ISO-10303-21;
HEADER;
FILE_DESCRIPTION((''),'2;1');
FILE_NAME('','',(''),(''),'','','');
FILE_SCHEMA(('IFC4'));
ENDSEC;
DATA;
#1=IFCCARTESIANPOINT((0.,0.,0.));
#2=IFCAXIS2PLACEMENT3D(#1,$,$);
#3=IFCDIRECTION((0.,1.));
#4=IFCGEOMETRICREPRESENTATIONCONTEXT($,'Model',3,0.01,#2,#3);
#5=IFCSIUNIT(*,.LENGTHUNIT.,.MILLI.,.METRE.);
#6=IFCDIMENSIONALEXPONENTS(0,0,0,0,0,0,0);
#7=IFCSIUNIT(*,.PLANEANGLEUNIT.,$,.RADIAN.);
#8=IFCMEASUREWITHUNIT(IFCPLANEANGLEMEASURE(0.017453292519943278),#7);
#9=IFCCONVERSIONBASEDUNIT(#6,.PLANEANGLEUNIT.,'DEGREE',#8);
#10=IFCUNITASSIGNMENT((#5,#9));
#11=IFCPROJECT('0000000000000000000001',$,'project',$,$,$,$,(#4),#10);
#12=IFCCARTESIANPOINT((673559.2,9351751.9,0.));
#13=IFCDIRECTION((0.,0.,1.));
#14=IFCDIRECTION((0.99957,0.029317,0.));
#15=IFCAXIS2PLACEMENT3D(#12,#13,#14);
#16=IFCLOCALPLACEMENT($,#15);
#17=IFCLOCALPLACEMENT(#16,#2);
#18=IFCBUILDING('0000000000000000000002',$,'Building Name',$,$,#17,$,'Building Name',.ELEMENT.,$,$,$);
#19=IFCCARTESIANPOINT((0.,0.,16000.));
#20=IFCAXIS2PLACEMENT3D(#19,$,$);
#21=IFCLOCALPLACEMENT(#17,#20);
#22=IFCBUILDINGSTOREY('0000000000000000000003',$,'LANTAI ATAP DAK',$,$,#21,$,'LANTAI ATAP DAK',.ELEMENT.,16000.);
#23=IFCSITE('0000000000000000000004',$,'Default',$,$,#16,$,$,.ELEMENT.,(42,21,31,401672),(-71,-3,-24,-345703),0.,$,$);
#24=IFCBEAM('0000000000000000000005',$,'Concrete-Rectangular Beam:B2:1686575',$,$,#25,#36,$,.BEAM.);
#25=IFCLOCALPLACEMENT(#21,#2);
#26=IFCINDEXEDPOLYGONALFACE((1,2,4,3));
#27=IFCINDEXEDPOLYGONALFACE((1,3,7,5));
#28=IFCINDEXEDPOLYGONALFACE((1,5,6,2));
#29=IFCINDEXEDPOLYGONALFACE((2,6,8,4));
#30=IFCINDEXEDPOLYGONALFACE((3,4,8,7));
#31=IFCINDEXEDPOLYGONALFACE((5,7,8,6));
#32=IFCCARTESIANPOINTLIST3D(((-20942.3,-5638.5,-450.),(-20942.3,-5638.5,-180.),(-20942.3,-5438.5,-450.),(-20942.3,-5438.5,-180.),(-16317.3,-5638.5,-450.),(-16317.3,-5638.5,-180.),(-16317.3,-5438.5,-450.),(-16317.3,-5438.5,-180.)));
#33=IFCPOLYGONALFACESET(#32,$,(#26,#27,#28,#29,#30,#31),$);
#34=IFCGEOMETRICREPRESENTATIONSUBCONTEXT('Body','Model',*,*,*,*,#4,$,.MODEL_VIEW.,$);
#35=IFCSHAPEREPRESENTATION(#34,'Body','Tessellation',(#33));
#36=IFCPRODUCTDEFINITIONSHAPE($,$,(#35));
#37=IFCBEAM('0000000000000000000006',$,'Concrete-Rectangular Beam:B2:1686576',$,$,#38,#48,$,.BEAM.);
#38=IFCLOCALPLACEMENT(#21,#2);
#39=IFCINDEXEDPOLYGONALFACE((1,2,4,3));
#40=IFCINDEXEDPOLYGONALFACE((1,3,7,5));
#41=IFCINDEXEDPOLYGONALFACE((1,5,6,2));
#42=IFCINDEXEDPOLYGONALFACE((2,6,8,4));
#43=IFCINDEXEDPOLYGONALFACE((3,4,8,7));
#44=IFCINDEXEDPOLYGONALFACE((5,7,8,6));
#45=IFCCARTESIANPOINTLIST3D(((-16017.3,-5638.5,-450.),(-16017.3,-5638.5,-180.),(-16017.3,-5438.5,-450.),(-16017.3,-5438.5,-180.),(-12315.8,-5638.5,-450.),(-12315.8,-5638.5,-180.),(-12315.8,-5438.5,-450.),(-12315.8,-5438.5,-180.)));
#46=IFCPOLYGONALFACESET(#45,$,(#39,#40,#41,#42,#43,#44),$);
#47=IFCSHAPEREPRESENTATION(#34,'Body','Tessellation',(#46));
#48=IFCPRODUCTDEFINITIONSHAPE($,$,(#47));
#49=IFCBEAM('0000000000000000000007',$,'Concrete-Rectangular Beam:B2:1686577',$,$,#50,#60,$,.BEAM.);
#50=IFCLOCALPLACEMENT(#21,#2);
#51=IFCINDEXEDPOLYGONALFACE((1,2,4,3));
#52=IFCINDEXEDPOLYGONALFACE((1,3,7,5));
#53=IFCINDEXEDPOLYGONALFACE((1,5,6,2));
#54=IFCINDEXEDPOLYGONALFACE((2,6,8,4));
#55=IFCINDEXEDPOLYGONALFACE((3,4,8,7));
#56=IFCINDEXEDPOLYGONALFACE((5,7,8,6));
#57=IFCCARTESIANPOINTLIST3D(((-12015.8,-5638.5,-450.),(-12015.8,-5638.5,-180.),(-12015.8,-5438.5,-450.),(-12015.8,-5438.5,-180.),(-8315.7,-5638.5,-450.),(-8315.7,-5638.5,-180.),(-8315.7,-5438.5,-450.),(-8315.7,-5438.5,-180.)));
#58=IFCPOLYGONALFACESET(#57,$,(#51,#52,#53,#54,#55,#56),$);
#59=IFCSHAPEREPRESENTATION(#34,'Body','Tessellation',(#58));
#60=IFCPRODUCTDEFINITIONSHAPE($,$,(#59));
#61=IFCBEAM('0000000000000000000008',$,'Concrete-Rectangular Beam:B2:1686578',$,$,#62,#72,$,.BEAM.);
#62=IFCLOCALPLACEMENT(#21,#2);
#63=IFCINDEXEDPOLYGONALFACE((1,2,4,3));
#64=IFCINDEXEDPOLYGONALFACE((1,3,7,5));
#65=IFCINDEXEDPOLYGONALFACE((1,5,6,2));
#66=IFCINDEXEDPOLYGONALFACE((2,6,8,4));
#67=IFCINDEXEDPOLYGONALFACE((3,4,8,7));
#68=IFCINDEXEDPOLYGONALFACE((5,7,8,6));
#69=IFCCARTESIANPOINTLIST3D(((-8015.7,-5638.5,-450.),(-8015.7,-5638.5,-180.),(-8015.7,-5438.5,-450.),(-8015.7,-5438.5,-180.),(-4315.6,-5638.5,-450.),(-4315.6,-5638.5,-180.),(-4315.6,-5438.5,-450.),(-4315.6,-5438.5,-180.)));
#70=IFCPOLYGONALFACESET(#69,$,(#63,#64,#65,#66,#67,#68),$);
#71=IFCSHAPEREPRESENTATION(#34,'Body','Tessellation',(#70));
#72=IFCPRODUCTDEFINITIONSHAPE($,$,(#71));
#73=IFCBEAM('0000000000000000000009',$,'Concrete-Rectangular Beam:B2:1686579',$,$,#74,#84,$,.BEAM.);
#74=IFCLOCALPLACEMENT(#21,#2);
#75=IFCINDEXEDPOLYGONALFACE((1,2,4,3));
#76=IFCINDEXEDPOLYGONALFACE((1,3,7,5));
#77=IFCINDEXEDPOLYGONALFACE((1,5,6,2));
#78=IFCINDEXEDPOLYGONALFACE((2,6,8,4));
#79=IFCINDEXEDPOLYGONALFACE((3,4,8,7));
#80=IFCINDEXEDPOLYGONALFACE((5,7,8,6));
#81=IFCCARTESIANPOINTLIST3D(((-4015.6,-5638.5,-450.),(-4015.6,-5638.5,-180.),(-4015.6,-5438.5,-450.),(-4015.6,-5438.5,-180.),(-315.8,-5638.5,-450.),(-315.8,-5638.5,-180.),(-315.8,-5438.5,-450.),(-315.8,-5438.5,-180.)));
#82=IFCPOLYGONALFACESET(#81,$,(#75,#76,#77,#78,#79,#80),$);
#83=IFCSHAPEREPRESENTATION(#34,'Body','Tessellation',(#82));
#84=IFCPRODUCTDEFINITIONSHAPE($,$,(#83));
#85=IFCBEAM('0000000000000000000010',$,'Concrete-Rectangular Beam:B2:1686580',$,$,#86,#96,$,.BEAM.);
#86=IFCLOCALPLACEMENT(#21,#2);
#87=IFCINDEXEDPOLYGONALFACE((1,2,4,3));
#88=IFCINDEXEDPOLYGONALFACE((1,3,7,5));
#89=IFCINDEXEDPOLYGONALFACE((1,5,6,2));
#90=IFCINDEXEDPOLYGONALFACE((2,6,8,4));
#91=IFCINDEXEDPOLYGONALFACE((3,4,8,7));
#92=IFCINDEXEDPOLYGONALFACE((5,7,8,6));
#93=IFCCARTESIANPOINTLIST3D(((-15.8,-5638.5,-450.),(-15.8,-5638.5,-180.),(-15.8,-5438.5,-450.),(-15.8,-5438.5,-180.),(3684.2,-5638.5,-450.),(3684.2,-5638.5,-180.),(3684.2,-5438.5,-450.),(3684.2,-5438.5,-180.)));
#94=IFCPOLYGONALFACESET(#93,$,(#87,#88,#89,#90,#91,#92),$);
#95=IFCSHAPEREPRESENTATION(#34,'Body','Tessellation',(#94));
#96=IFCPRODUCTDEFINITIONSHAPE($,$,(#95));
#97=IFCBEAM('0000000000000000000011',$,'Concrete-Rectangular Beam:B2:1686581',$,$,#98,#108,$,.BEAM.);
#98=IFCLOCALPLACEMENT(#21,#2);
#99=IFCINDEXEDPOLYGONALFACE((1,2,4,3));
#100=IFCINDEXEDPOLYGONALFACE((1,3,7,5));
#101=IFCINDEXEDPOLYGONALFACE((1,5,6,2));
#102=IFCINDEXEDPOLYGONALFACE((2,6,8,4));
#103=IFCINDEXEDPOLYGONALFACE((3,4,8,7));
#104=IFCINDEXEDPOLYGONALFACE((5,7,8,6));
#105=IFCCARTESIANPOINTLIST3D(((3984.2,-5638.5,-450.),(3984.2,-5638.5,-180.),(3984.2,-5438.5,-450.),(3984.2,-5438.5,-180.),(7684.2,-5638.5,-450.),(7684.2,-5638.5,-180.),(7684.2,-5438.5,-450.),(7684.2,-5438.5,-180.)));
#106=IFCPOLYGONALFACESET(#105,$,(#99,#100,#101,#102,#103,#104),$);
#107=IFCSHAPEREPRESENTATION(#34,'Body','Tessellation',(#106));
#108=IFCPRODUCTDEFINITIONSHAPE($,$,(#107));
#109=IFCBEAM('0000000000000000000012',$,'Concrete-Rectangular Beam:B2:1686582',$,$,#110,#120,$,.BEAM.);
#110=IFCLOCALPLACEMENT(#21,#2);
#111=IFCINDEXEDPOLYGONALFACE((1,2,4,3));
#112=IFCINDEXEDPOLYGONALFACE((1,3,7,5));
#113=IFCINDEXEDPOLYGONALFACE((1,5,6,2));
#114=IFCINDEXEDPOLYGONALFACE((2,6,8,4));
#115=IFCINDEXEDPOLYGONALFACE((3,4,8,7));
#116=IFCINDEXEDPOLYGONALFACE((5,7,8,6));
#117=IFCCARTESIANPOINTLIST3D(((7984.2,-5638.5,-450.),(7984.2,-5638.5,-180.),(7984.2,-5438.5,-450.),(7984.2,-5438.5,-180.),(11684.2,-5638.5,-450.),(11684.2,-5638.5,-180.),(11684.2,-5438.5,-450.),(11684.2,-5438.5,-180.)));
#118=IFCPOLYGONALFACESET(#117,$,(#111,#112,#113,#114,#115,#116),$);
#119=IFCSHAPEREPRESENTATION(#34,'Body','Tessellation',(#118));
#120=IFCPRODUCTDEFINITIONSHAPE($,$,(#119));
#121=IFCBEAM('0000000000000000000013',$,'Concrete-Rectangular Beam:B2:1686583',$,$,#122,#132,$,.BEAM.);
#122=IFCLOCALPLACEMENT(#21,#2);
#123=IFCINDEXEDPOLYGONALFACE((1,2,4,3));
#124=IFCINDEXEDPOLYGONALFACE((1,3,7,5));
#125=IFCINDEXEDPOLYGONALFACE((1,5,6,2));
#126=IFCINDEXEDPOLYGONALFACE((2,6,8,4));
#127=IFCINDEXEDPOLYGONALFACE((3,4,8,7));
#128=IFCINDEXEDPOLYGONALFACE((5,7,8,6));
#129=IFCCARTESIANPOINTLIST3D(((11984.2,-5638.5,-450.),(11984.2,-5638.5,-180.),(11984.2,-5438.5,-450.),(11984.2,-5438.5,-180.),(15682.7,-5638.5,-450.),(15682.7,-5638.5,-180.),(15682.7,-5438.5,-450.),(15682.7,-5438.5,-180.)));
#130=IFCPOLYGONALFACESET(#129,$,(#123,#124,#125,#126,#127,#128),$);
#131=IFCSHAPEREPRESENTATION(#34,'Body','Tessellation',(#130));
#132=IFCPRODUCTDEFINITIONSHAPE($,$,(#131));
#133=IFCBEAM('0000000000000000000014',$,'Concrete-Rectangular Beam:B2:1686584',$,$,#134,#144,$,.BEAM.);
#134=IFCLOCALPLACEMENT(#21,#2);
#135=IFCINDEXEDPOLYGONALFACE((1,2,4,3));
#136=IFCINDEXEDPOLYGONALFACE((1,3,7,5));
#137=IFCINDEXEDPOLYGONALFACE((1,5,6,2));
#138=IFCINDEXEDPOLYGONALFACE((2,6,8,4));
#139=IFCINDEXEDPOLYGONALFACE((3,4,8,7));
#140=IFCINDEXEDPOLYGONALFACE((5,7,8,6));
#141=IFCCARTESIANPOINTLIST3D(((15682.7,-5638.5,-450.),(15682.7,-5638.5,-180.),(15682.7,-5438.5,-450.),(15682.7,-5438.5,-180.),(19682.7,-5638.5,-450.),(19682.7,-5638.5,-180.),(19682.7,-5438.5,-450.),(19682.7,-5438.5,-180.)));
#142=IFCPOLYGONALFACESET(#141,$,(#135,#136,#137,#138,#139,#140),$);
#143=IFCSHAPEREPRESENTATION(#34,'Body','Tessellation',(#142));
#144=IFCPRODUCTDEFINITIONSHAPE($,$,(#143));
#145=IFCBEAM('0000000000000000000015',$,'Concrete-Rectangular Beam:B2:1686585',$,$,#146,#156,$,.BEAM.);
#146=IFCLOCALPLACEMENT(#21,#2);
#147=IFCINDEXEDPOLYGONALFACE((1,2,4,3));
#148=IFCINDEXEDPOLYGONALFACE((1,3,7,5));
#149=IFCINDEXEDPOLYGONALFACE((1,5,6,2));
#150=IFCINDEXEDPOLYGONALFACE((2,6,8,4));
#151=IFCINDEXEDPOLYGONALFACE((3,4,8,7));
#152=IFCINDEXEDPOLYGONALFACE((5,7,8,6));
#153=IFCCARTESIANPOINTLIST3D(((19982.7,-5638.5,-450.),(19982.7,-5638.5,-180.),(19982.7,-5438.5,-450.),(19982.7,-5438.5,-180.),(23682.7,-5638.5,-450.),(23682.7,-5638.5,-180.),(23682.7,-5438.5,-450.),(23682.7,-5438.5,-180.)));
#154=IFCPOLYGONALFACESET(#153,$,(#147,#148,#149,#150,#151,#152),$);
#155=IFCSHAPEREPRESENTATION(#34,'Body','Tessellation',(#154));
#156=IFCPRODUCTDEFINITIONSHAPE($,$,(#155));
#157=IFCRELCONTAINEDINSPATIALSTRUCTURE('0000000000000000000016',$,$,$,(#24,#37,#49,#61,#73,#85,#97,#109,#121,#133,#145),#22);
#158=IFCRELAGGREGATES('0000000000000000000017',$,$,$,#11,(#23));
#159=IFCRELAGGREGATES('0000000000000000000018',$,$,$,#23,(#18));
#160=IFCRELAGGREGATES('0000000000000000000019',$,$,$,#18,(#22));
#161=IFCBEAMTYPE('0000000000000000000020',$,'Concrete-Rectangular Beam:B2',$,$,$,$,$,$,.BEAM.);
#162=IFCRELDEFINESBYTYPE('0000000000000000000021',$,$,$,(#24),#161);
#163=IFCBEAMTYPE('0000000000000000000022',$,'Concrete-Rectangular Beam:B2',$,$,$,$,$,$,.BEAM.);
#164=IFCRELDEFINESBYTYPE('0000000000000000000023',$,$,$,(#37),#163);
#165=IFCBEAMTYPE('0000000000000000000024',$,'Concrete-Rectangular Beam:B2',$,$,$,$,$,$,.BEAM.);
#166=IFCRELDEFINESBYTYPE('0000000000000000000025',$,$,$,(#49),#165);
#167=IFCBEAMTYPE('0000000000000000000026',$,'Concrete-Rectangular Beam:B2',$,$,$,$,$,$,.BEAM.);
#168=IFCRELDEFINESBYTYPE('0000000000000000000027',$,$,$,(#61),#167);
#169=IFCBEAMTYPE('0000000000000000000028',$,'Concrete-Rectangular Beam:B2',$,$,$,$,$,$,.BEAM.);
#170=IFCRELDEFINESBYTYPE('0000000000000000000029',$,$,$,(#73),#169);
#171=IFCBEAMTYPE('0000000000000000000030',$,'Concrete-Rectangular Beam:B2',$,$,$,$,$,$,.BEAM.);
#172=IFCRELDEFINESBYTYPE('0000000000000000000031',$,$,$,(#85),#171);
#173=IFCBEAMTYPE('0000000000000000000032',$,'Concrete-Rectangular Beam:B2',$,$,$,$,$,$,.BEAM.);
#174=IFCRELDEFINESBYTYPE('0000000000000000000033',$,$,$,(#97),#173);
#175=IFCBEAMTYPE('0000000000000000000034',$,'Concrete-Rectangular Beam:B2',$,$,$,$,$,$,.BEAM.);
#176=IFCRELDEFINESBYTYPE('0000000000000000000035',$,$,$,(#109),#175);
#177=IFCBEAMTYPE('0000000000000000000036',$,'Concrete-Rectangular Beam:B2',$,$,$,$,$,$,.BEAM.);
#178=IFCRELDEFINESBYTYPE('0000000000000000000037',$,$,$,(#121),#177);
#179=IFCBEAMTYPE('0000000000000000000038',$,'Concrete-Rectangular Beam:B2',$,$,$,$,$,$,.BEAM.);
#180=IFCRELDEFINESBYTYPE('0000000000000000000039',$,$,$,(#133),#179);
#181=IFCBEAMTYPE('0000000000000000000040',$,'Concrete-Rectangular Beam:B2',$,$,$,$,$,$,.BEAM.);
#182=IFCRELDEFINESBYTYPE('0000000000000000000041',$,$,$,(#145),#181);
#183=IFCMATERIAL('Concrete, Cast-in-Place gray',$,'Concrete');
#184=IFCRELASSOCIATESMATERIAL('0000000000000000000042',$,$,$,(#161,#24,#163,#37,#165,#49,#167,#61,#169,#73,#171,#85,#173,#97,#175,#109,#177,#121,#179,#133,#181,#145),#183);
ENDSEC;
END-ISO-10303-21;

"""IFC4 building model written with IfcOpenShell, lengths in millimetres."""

from ifc_helpers import new_model, entity, si_unit, converted_unit, direction, frame, origin, place, context, subcontext, project, spatial, indexed_curve, outline, extrude, source, transform, mapped, material, type_object, type_shapes, element, save


model = new_model("IFC4")

# Units and contexts
model_context = context("Model", 3, precision=0.01, world=origin(), true_north=direction((0.0, 1.0)))
body_context = subcontext(model_context, "Body", "Model", "MODEL_VIEW")
ifc_project = project(units=[si_unit("LENGTHUNIT", "METRE", prefix="MILLI"), converted_unit("PLANEANGLEUNIT", "DEGREE", entity("IfcPlaneAngleMeasure", 0.017453292519943278), si_unit("PLANEANGLEUNIT", "RADIAN"), dimensions=[0, 0, 0, 0, 0, 0, 0])], contexts=[model_context])

# Site, building, storey
site_placement = place(None, frame((673559.2, 9351751.9, 0.0), z_axis=(0.0, 0.0, 1.0), x_axis=(0.99957, 0.029317, 0.0)))
site = spatial("IfcSite", under=ifc_project, at=site_placement, Name="Default", CompositionType="ELEMENT", RefLatitude=(42, 21, 31, 401672), RefLongitude=(-71, -3, -24, -345703), RefElevation=0.0)
building_placement = place(site_placement, origin())
building = spatial("IfcBuilding", under=site, at=building_placement, Name="Building Name", LongName="Building Name", CompositionType="ELEMENT")
storey_placement = place(building_placement, frame((0.0, 0.0, 16000.0)))
storey = spatial("IfcBuildingStorey", under=building, at=storey_placement, Name="LANTAI ATAP DAK", LongName="LANTAI ATAP DAK", CompositionType="ELEMENT", Elevation=16000.0)

# Beams
ifc_material = material(Name="Concrete, Cast-in-Place gray", Category="Concrete")
beam_type_1 = type_object("IfcBeamType", Name="Concrete-Rectangular Beam:B2", PredefinedType="BEAM", material=ifc_material)
shared_shape_1 = source(origin(), body_context, "Body", "SweptSolid", [
    extrude(outline(indexed_curve([(-135.0, -100.0), (135.0, -100.0), (135.0, 100.0), (-135.0, 100.0), (-135.0, -100.0)], self_intersect=False)), frame((-20942.3, -5538.5, 15685.0), z_axis=(1.0, 0.0, 0.0), x_axis=(0.0, 0.0, -1.0)), (0.0, 0.0, 1.0), 4625.0),
])
type_shapes(beam_type_1, [shared_shape_1])
beam_1_placement = place(storey_placement, frame((0.0, 0.0, -16000.0)))
element("IfcBeam", 1, at=beam_1_placement, inside=storey, type_object=beam_type_1, material=ifc_material, Name="Concrete-Rectangular Beam:B2:1686575", PredefinedType="BEAM", context=body_context, shape_type="MappedRepresentation", body=[
    mapped(shared_shape_1, transform((0.0, 0.0, 0.0), scale=1.0)),
])
beam_type_2 = type_object("IfcBeamType", Name="Concrete-Rectangular Beam:B2", PredefinedType="BEAM", material=ifc_material)
shared_shape_2 = source(origin(), body_context, "Body", "SweptSolid", [
    extrude(outline(indexed_curve([(-135.0, -100.0), (135.0, -100.0), (135.0, 100.0), (-135.0, 100.0), (-135.0, -100.0)], self_intersect=False)), frame((-16017.3, -5538.5, 15685.0), z_axis=(1.0, 0.0, 0.0), x_axis=(0.0, 0.0, -1.0)), (0.0, 0.0, 1.0), 3701.5),
])
type_shapes(beam_type_2, [shared_shape_2])
beam_2_placement = place(storey_placement, frame((0.0, 0.0, -16000.0)))
element("IfcBeam", 2, at=beam_2_placement, inside=storey, type_object=beam_type_2, material=ifc_material, Name="Concrete-Rectangular Beam:B2:1686576", PredefinedType="BEAM", context=body_context, shape_type="MappedRepresentation", body=[
    mapped(shared_shape_2, transform((0.0, 0.0, 0.0), scale=1.0)),
])
beam_type_3 = type_object("IfcBeamType", Name="Concrete-Rectangular Beam:B2", PredefinedType="BEAM", material=ifc_material)
shared_shape_3 = source(origin(), body_context, "Body", "SweptSolid", [
    extrude(outline(indexed_curve([(-135.0, -100.0), (135.0, -100.0), (135.0, 100.0), (-135.0, 100.0), (-135.0, -100.0)], self_intersect=False)), frame((-8315.7, -5538.5, 15685.0), z_axis=(-1.0, 0.0, 0.0), x_axis=(0.0, 0.0, -1.0)), (0.0, 0.0, 1.0), 3700.1),
])
type_shapes(beam_type_3, [shared_shape_3])
beam_3_placement = place(storey_placement, frame((0.0, 0.0, -16000.0)))
element("IfcBeam", 3, at=beam_3_placement, inside=storey, type_object=beam_type_3, material=ifc_material, Name="Concrete-Rectangular Beam:B2:1686577", PredefinedType="BEAM", context=body_context, shape_type="MappedRepresentation", body=[
    mapped(shared_shape_3, transform((0.0, 0.0, 0.0), scale=1.0)),
])
beam_type_4 = type_object("IfcBeamType", Name="Concrete-Rectangular Beam:B2", PredefinedType="BEAM", material=ifc_material)
shared_shape_4 = source(origin(), body_context, "Body", "SweptSolid", [
    extrude(outline(indexed_curve([(-135.0, -100.0), (135.0, -100.0), (135.0, 100.0), (-135.0, 100.0), (-135.0, -100.0)], self_intersect=False)), frame((-8015.7, -5538.5, 15685.0), z_axis=(1.0, 0.0, 0.0), x_axis=(0.0, 0.0, -1.0)), (0.0, 0.0, 1.0), 3700.1),
])
type_shapes(beam_type_4, [shared_shape_4])
beam_4_placement = place(storey_placement, frame((0.0, 0.0, -16000.0)))
element("IfcBeam", 4, at=beam_4_placement, inside=storey, type_object=beam_type_4, material=ifc_material, Name="Concrete-Rectangular Beam:B2:1686578", PredefinedType="BEAM", context=body_context, shape_type="MappedRepresentation", body=[
    mapped(shared_shape_4, transform((0.0, 0.0, 0.0), scale=1.0)),
])
beam_type_5 = type_object("IfcBeamType", Name="Concrete-Rectangular Beam:B2", PredefinedType="BEAM", material=ifc_material)
shared_shape_5 = source(origin(), body_context, "Body", "SweptSolid", [
    extrude(outline(indexed_curve([(-135.0, -100.0), (135.0, -100.0), (135.0, 100.0), (-135.0, 100.0), (-135.0, -100.0)], self_intersect=False)), frame((-4015.6, -5538.5, 15685.0), z_axis=(1.0, 0.0, 0.0), x_axis=(0.0, 0.0, -1.0)), (0.0, 0.0, 1.0), 3699.7),
])
type_shapes(beam_type_5, [shared_shape_5])
beam_5_placement = place(storey_placement, frame((0.0, 0.0, -16000.0)))
element("IfcBeam", 5, at=beam_5_placement, inside=storey, type_object=beam_type_5, material=ifc_material, Name="Concrete-Rectangular Beam:B2:1686579", PredefinedType="BEAM", context=body_context, shape_type="MappedRepresentation", body=[
    mapped(shared_shape_5, transform((0.0, 0.0, 0.0), scale=1.0)),
])
beam_type_6 = type_object("IfcBeamType", Name="Concrete-Rectangular Beam:B2", PredefinedType="BEAM", material=ifc_material)
shared_shape_6 = source(origin(), body_context, "Body", "SweptSolid", [
    extrude(outline(indexed_curve([(-135.0, -100.0), (135.0, -100.0), (135.0, 100.0), (-135.0, 100.0), (-135.0, -100.0)], self_intersect=False)), frame((-15.8, -5538.5, 15685.0), z_axis=(1.0, 0.0, 0.0), x_axis=(0.0, 0.0, -1.0)), (0.0, 0.0, 1.0), 3700.0),
])
type_shapes(beam_type_6, [shared_shape_6])
beam_6_placement = place(storey_placement, frame((0.0, 0.0, -16000.0)))
element("IfcBeam", 6, at=beam_6_placement, inside=storey, type_object=beam_type_6, material=ifc_material, Name="Concrete-Rectangular Beam:B2:1686580", PredefinedType="BEAM", context=body_context, shape_type="MappedRepresentation", body=[
    mapped(shared_shape_6, transform((0.0, 0.0, 0.0), scale=1.0)),
])
beam_type_7 = type_object("IfcBeamType", Name="Concrete-Rectangular Beam:B2", PredefinedType="BEAM", material=ifc_material)
shared_shape_7 = source(origin(), body_context, "Body", "SweptSolid", [
    extrude(outline(indexed_curve([(-135.0, -100.0), (135.0, -100.0), (135.0, 100.0), (-135.0, 100.0), (-135.0, -100.0)], self_intersect=False)), frame((3984.2, -5538.5, 15685.0), z_axis=(1.0, 0.0, 0.0), x_axis=(0.0, 0.0, -1.0)), (0.0, 0.0, 1.0), 3700.0),
])
type_shapes(beam_type_7, [shared_shape_7])
beam_7_placement = place(storey_placement, frame((0.0, 0.0, -16000.0)))
element("IfcBeam", 7, at=beam_7_placement, inside=storey, type_object=beam_type_7, material=ifc_material, Name="Concrete-Rectangular Beam:B2:1686581", PredefinedType="BEAM", context=body_context, shape_type="MappedRepresentation", body=[
    mapped(shared_shape_7, transform((0.0, 0.0, 0.0), scale=1.0)),
])
beam_type_8 = type_object("IfcBeamType", Name="Concrete-Rectangular Beam:B2", PredefinedType="BEAM", material=ifc_material)
shared_shape_8 = source(origin(), body_context, "Body", "SweptSolid", [
    extrude(outline(indexed_curve([(-135.0, -100.0), (135.0, -100.0), (135.0, 100.0), (-135.0, 100.0), (-135.0, -100.0)], self_intersect=False)), frame((7984.2, -5538.5, 15685.0), z_axis=(1.0, 0.0, 0.0), x_axis=(0.0, 0.0, -1.0)), (0.0, 0.0, 1.0), 3700.0),
])
type_shapes(beam_type_8, [shared_shape_8])
beam_8_placement = place(storey_placement, frame((0.0, 0.0, -16000.0)))
element("IfcBeam", 8, at=beam_8_placement, inside=storey, type_object=beam_type_8, material=ifc_material, Name="Concrete-Rectangular Beam:B2:1686582", PredefinedType="BEAM", context=body_context, shape_type="MappedRepresentation", body=[
    mapped(shared_shape_8, transform((0.0, 0.0, 0.0), scale=1.0)),
])
beam_type_9 = type_object("IfcBeamType", Name="Concrete-Rectangular Beam:B2", PredefinedType="BEAM", material=ifc_material)
shared_shape_9 = source(origin(), body_context, "Body", "SweptSolid", [
    extrude(outline(indexed_curve([(-135.0, -100.0), (135.0, -100.0), (135.0, 100.0), (-135.0, 100.0), (-135.0, -100.0)], self_intersect=False)), frame((11984.2, -5538.5, 15685.0), z_axis=(1.0, 0.0, 0.0), x_axis=(0.0, 0.0, -1.0)), (0.0, 0.0, 1.0), 3698.5),
])
type_shapes(beam_type_9, [shared_shape_9])
beam_9_placement = place(storey_placement, frame((0.0, 0.0, -16000.0)))
element("IfcBeam", 9, at=beam_9_placement, inside=storey, type_object=beam_type_9, material=ifc_material, Name="Concrete-Rectangular Beam:B2:1686583", PredefinedType="BEAM", context=body_context, shape_type="MappedRepresentation", body=[
    mapped(shared_shape_9, transform((0.0, 0.0, 0.0), scale=1.0)),
])
beam_type_10 = type_object("IfcBeamType", Name="Concrete-Rectangular Beam:B2", PredefinedType="BEAM", material=ifc_material)
shared_shape_10 = source(origin(), body_context, "Body", "SweptSolid", [
    extrude(outline(indexed_curve([(-135.0, -100.0), (135.0, -100.0), (135.0, 100.0), (-135.0, 100.0), (-135.0, -100.0)], self_intersect=False)), frame((15682.7, -5538.5, 15685.0), z_axis=(1.0, 0.0, 0.0), x_axis=(0.0, 0.0, -1.0)), (0.0, 0.0, 1.0), 4000.0),
])
type_shapes(beam_type_10, [shared_shape_10])
beam_10_placement = place(storey_placement, frame((0.0, 0.0, -16000.0)))
element("IfcBeam", 10, at=beam_10_placement, inside=storey, type_object=beam_type_10, material=ifc_material, Name="Concrete-Rectangular Beam:B2:1686584", PredefinedType="BEAM", context=body_context, shape_type="MappedRepresentation", body=[
    mapped(shared_shape_10, transform((0.0, 0.0, 0.0), scale=1.0)),
])
beam_type_11 = type_object("IfcBeamType", Name="Concrete-Rectangular Beam:B2", PredefinedType="BEAM", material=ifc_material)
shared_shape_11 = source(origin(), body_context, "Body", "SweptSolid", [
    extrude(outline(indexed_curve([(-135.0, -100.0), (135.0, -100.0), (135.0, 100.0), (-135.0, 100.0), (-135.0, -100.0)], self_intersect=False)), frame((19982.7, -5538.5, 15685.0), z_axis=(1.0, 0.0, 0.0), x_axis=(0.0, 0.0, -1.0)), (0.0, 0.0, 1.0), 3700.0),
])
type_shapes(beam_type_11, [shared_shape_11])
beam_11_placement = place(storey_placement, frame((0.0, 0.0, -16000.0)))
element("IfcBeam", 11, at=beam_11_placement, inside=storey, type_object=beam_type_11, material=ifc_material, Name="Concrete-Rectangular Beam:B2:1686585", PredefinedType="BEAM", context=body_context, shape_type="MappedRepresentation", body=[
    mapped(shared_shape_11, transform((0.0, 0.0, 0.0), scale=1.0)),
])

save(model, "model.ifc")
